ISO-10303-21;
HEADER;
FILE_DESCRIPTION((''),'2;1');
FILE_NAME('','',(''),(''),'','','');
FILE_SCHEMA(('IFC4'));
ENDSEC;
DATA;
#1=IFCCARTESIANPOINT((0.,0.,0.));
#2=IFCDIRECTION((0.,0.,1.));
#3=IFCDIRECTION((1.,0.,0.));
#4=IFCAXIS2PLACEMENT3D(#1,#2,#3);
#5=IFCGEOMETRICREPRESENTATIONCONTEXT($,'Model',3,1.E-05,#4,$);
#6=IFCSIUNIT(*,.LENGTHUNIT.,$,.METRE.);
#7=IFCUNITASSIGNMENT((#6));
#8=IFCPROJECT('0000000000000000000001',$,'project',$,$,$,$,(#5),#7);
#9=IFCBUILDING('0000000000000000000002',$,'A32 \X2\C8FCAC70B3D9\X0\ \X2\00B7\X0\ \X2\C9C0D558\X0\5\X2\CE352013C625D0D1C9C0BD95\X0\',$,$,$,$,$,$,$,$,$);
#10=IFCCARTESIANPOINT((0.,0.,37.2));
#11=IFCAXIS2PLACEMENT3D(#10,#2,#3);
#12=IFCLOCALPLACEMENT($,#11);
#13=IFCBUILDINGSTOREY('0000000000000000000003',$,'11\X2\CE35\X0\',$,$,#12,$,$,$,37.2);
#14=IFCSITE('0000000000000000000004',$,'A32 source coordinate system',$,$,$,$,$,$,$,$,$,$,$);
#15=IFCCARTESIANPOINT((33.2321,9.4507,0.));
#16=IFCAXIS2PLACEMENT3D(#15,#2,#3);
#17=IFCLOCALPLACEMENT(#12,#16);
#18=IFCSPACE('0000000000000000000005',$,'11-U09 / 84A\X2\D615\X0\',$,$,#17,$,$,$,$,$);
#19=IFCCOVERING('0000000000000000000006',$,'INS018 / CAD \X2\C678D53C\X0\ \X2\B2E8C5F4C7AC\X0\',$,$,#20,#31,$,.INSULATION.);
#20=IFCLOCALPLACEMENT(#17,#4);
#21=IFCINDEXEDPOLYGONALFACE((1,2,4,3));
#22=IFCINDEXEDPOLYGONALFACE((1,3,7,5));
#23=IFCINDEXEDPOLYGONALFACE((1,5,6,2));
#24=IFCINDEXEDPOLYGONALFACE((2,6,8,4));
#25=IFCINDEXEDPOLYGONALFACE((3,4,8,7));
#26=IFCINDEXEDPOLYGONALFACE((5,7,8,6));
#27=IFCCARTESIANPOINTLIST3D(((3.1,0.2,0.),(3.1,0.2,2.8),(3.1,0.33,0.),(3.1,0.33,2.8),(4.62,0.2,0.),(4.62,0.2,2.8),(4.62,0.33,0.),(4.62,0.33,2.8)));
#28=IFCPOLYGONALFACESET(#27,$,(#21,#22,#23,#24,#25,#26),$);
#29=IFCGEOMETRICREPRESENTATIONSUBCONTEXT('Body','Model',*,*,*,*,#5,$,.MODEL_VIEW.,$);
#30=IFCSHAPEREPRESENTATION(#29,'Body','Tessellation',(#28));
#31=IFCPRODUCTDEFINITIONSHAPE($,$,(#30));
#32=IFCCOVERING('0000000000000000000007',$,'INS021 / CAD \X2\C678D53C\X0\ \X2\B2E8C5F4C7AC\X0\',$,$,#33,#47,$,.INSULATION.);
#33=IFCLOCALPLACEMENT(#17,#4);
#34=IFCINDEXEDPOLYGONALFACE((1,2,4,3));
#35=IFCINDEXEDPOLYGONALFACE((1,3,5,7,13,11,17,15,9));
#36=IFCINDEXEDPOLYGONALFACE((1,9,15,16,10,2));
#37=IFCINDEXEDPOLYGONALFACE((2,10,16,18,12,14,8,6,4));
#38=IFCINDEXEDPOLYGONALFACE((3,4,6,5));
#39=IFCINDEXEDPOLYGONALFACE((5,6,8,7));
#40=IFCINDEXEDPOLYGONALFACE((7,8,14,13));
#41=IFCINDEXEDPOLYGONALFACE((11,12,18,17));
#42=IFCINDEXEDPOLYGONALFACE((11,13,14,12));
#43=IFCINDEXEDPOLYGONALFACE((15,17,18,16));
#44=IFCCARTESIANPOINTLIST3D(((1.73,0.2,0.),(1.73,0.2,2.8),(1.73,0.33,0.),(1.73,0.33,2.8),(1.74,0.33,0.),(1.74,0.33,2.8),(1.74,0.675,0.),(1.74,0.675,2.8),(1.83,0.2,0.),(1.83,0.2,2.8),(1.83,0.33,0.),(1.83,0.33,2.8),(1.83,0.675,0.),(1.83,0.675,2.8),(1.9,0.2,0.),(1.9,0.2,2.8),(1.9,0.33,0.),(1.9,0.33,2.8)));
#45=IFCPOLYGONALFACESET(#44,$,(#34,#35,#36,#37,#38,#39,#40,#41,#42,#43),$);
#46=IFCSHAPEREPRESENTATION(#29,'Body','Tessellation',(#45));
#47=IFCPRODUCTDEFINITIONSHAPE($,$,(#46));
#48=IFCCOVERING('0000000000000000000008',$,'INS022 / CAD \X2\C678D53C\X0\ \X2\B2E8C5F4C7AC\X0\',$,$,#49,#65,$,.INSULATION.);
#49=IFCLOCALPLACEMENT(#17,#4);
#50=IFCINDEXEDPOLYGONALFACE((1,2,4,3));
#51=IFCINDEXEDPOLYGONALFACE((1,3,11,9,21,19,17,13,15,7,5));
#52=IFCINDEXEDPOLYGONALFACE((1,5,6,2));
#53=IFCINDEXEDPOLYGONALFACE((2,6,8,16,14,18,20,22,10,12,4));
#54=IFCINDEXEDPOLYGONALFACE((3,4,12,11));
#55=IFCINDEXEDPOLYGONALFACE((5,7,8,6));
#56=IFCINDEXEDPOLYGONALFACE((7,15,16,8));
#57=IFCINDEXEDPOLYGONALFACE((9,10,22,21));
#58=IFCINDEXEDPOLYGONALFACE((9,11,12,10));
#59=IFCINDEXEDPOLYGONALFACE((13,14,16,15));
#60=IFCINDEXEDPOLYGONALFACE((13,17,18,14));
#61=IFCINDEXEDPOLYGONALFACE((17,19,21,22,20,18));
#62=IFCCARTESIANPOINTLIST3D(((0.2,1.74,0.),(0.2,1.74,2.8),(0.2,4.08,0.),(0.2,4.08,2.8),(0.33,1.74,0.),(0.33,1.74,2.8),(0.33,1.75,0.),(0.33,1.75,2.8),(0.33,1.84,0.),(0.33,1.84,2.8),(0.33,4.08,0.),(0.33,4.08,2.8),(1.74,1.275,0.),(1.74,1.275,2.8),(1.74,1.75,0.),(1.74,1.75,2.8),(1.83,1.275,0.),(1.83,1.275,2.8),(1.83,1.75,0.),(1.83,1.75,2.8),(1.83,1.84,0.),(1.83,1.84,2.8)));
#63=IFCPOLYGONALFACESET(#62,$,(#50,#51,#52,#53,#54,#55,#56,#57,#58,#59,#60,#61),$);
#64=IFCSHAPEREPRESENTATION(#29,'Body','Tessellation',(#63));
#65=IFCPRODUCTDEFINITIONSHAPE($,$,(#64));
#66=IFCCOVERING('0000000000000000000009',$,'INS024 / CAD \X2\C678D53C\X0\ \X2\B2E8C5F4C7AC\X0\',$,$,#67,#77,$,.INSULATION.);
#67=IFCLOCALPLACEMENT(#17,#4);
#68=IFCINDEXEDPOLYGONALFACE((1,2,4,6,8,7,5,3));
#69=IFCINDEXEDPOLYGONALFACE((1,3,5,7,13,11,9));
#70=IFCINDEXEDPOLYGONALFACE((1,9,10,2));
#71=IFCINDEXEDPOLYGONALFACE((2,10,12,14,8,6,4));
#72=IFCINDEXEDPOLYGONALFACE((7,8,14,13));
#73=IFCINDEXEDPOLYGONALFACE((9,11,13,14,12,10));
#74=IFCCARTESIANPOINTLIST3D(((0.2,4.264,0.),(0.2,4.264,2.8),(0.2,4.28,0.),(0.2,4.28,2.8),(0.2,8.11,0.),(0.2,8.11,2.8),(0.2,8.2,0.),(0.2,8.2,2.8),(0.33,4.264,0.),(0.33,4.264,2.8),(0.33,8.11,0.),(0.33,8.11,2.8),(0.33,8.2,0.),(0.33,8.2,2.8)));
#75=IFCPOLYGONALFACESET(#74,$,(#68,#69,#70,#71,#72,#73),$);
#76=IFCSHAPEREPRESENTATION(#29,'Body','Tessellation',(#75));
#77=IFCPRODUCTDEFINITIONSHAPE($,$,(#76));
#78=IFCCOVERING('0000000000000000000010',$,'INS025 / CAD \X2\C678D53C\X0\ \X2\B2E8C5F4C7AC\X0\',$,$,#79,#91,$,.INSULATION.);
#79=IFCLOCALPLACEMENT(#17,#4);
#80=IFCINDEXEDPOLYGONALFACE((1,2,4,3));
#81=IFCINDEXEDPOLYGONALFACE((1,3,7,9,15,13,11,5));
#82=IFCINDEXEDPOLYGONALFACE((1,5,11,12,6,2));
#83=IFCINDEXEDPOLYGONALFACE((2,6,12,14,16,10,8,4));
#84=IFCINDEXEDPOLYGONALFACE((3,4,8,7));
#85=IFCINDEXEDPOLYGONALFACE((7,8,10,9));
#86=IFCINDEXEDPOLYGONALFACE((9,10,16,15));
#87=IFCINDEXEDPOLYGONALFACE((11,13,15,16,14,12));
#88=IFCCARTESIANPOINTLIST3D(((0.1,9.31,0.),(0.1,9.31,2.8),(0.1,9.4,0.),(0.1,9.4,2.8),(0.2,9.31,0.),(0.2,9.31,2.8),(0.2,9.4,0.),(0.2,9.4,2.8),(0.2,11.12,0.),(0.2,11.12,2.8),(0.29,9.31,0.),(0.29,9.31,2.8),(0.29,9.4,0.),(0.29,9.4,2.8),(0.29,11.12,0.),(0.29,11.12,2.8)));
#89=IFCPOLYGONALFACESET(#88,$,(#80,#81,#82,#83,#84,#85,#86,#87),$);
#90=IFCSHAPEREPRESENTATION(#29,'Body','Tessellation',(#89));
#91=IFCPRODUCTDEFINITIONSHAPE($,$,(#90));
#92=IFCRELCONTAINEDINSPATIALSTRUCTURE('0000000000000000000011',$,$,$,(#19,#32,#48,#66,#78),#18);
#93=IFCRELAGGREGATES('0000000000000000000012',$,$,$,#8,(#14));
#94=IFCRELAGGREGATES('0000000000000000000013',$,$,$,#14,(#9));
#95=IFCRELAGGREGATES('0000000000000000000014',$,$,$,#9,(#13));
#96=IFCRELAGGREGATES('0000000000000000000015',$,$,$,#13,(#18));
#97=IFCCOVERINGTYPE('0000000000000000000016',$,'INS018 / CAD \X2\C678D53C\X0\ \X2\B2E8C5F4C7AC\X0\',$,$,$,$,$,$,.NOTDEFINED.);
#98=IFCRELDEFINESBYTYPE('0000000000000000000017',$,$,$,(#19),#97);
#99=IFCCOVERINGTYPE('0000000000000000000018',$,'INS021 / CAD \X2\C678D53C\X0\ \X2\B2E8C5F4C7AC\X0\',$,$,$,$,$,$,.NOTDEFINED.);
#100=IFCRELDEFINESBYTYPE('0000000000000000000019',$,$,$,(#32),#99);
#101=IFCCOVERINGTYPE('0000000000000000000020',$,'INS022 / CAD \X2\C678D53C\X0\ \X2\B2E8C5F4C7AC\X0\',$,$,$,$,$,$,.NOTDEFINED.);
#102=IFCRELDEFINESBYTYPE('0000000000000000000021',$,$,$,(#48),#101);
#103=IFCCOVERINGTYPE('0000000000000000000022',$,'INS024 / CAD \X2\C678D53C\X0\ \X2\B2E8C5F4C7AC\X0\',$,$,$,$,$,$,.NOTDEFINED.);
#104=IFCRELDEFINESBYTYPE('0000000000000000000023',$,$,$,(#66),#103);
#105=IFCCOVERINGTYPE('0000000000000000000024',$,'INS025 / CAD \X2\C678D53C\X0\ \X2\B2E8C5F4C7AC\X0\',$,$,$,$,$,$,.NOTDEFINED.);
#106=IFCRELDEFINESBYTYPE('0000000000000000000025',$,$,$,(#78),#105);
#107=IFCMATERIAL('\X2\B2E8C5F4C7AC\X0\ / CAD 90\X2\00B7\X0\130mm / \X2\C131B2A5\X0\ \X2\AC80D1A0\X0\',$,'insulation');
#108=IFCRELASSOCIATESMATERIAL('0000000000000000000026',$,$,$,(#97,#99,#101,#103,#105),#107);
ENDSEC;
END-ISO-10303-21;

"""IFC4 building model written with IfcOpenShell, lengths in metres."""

from ifc_helpers import new_model, si_unit, frame, origin, origin_with_axes, place, context, subcontext, project, spatial, polyline, outline, extrude, source, transform, mapped, material, type_object, type_shapes, element, save


model = new_model("IFC4")

# Units and contexts
model_context = context("Model", 3, precision=1e-05, world=origin_with_axes())
body_context = subcontext(model_context, "Body", "Model", "MODEL_VIEW")
ifc_project = project(units=[si_unit("LENGTHUNIT", "METRE")], contexts=[model_context])

# Site, building, storey, space
storey_placement = place(None, frame((0.0, 0.0, 37.2), z_axis=(0.0, 0.0, 1.0), x_axis=(1.0, 0.0, 0.0)))
space_placement = place(storey_placement, frame((33.2321, 9.4507, 0.0), z_axis=(0.0, 0.0, 1.0), x_axis=(1.0, 0.0, 0.0)))
site = spatial("IfcSite", under=ifc_project, Name="A32 source coordinate system")
building = spatial("IfcBuilding", under=site, Name="A32 주거동 · 지하5층–옥탑지붕")
storey = spatial("IfcBuildingStorey", under=building, at=storey_placement, Name="11층", Elevation=37.2)
space = spatial("IfcSpace", under=storey, at=space_placement, Name="11-U09 / 84A형")

# Coverings
ifc_material = material(Name="단열재 / CAD 90·130mm / 성능 검토", Category="insulation")
covering_type_1 = type_object("IfcCoveringType", Name="INS018 / CAD 외피 단열재", PredefinedType="NOTDEFINED", material=ifc_material)
shared_shape_1 = source(origin(), body_context, "Body", "SweptSolid", [
    extrude(outline(polyline([(3.1, 0.33), (4.62, 0.33), (4.62, 0.2), (3.1, 0.2), (3.1, 0.33)])), origin(), (0.0, 0.0, 1.0), 2.8),
])
type_shapes(covering_type_1, [shared_shape_1])
covering_1_placement = place(space_placement, origin_with_axes())
element("IfcCovering", 1, at=covering_1_placement, inside=space, type_object=covering_type_1, Name="INS018 / CAD 외피 단열재", PredefinedType="INSULATION", context=body_context, shape_type="MappedRepresentation", body=[
    mapped(shared_shape_1, transform((0.0, 0.0, 0.0), scale=1.0)),
])
covering_type_2 = type_object("IfcCoveringType", Name="INS021 / CAD 외피 단열재", PredefinedType="NOTDEFINED", material=ifc_material)
shared_shape_2 = source(origin(), body_context, "Body", "SweptSolid", [
    extrude(outline(polyline([(1.83, 0.33), (1.9, 0.33), (1.9, 0.2), (1.83, 0.2), (1.73, 0.2), (1.73, 0.33), (1.74, 0.33), (1.74, 0.675), (1.83, 0.675), (1.83, 0.33)])), origin(), (0.0, 0.0, 1.0), 2.8),
])
type_shapes(covering_type_2, [shared_shape_2])
covering_2_placement = place(space_placement, origin_with_axes())
element("IfcCovering", 2, at=covering_2_placement, inside=space, type_object=covering_type_2, Name="INS021 / CAD 외피 단열재", PredefinedType="INSULATION", context=body_context, shape_type="MappedRepresentation", body=[
    mapped(shared_shape_2, transform((0.0, 0.0, 0.0), scale=1.0)),
])
covering_type_3 = type_object("IfcCoveringType", Name="INS022 / CAD 외피 단열재", PredefinedType="NOTDEFINED", material=ifc_material)
shared_shape_3 = source(origin(), body_context, "Body", "SweptSolid", [
    extrude(outline(polyline([(1.83, 1.84), (1.83, 1.75), (1.83, 1.275), (1.74, 1.275), (1.74, 1.75), (0.33, 1.75), (0.33, 1.74), (0.2, 1.74), (0.2, 4.08), (0.33, 4.08), (0.33, 1.84), (1.83, 1.84)])), origin(), (0.0, 0.0, 1.0), 2.8),
])
type_shapes(covering_type_3, [shared_shape_3])
covering_3_placement = place(space_placement, origin_with_axes())
element("IfcCovering", 3, at=covering_3_placement, inside=space, type_object=covering_type_3, Name="INS022 / CAD 외피 단열재", PredefinedType="INSULATION", context=body_context, shape_type="MappedRepresentation", body=[
    mapped(shared_shape_3, transform((0.0, 0.0, 0.0), scale=1.0)),
])
covering_type_4 = type_object("IfcCoveringType", Name="INS024 / CAD 외피 단열재", PredefinedType="NOTDEFINED", material=ifc_material)
shared_shape_4 = source(origin(), body_context, "Body", "SweptSolid", [
    extrude(outline(polyline([(0.2, 8.11), (0.2, 8.2), (0.33, 8.2), (0.33, 8.11), (0.33, 4.264), (0.2, 4.264), (0.2, 4.28), (0.2, 8.11)])), origin(), (0.0, 0.0, 1.0), 2.8),
])
type_shapes(covering_type_4, [shared_shape_4])
covering_4_placement = place(space_placement, origin_with_axes())
element("IfcCovering", 4, at=covering_4_placement, inside=space, type_object=covering_type_4, Name="INS024 / CAD 외피 단열재", PredefinedType="INSULATION", context=body_context, shape_type="MappedRepresentation", body=[
    mapped(shared_shape_4, transform((0.0, 0.0, 0.0), scale=1.0)),
])
covering_type_5 = type_object("IfcCoveringType", Name="INS025 / CAD 외피 단열재", PredefinedType="NOTDEFINED", material=ifc_material)
shared_shape_5 = source(origin(), body_context, "Body", "SweptSolid", [
    extrude(outline(polyline([(0.2, 9.4), (0.2, 11.12), (0.29, 11.12), (0.29, 9.4), (0.29, 9.31), (0.2, 9.31), (0.1, 9.31), (0.1, 9.4), (0.2, 9.4)])), origin(), (0.0, 0.0, 1.0), 2.8),
])
type_shapes(covering_type_5, [shared_shape_5])
covering_5_placement = place(space_placement, origin_with_axes())
element("IfcCovering", 5, at=covering_5_placement, inside=space, type_object=covering_type_5, Name="INS025 / CAD 외피 단열재", PredefinedType="INSULATION", context=body_context, shape_type="MappedRepresentation", body=[
    mapped(shared_shape_5, transform((0.0, 0.0, 0.0), scale=1.0)),
])

save(model, "model.ifc")
